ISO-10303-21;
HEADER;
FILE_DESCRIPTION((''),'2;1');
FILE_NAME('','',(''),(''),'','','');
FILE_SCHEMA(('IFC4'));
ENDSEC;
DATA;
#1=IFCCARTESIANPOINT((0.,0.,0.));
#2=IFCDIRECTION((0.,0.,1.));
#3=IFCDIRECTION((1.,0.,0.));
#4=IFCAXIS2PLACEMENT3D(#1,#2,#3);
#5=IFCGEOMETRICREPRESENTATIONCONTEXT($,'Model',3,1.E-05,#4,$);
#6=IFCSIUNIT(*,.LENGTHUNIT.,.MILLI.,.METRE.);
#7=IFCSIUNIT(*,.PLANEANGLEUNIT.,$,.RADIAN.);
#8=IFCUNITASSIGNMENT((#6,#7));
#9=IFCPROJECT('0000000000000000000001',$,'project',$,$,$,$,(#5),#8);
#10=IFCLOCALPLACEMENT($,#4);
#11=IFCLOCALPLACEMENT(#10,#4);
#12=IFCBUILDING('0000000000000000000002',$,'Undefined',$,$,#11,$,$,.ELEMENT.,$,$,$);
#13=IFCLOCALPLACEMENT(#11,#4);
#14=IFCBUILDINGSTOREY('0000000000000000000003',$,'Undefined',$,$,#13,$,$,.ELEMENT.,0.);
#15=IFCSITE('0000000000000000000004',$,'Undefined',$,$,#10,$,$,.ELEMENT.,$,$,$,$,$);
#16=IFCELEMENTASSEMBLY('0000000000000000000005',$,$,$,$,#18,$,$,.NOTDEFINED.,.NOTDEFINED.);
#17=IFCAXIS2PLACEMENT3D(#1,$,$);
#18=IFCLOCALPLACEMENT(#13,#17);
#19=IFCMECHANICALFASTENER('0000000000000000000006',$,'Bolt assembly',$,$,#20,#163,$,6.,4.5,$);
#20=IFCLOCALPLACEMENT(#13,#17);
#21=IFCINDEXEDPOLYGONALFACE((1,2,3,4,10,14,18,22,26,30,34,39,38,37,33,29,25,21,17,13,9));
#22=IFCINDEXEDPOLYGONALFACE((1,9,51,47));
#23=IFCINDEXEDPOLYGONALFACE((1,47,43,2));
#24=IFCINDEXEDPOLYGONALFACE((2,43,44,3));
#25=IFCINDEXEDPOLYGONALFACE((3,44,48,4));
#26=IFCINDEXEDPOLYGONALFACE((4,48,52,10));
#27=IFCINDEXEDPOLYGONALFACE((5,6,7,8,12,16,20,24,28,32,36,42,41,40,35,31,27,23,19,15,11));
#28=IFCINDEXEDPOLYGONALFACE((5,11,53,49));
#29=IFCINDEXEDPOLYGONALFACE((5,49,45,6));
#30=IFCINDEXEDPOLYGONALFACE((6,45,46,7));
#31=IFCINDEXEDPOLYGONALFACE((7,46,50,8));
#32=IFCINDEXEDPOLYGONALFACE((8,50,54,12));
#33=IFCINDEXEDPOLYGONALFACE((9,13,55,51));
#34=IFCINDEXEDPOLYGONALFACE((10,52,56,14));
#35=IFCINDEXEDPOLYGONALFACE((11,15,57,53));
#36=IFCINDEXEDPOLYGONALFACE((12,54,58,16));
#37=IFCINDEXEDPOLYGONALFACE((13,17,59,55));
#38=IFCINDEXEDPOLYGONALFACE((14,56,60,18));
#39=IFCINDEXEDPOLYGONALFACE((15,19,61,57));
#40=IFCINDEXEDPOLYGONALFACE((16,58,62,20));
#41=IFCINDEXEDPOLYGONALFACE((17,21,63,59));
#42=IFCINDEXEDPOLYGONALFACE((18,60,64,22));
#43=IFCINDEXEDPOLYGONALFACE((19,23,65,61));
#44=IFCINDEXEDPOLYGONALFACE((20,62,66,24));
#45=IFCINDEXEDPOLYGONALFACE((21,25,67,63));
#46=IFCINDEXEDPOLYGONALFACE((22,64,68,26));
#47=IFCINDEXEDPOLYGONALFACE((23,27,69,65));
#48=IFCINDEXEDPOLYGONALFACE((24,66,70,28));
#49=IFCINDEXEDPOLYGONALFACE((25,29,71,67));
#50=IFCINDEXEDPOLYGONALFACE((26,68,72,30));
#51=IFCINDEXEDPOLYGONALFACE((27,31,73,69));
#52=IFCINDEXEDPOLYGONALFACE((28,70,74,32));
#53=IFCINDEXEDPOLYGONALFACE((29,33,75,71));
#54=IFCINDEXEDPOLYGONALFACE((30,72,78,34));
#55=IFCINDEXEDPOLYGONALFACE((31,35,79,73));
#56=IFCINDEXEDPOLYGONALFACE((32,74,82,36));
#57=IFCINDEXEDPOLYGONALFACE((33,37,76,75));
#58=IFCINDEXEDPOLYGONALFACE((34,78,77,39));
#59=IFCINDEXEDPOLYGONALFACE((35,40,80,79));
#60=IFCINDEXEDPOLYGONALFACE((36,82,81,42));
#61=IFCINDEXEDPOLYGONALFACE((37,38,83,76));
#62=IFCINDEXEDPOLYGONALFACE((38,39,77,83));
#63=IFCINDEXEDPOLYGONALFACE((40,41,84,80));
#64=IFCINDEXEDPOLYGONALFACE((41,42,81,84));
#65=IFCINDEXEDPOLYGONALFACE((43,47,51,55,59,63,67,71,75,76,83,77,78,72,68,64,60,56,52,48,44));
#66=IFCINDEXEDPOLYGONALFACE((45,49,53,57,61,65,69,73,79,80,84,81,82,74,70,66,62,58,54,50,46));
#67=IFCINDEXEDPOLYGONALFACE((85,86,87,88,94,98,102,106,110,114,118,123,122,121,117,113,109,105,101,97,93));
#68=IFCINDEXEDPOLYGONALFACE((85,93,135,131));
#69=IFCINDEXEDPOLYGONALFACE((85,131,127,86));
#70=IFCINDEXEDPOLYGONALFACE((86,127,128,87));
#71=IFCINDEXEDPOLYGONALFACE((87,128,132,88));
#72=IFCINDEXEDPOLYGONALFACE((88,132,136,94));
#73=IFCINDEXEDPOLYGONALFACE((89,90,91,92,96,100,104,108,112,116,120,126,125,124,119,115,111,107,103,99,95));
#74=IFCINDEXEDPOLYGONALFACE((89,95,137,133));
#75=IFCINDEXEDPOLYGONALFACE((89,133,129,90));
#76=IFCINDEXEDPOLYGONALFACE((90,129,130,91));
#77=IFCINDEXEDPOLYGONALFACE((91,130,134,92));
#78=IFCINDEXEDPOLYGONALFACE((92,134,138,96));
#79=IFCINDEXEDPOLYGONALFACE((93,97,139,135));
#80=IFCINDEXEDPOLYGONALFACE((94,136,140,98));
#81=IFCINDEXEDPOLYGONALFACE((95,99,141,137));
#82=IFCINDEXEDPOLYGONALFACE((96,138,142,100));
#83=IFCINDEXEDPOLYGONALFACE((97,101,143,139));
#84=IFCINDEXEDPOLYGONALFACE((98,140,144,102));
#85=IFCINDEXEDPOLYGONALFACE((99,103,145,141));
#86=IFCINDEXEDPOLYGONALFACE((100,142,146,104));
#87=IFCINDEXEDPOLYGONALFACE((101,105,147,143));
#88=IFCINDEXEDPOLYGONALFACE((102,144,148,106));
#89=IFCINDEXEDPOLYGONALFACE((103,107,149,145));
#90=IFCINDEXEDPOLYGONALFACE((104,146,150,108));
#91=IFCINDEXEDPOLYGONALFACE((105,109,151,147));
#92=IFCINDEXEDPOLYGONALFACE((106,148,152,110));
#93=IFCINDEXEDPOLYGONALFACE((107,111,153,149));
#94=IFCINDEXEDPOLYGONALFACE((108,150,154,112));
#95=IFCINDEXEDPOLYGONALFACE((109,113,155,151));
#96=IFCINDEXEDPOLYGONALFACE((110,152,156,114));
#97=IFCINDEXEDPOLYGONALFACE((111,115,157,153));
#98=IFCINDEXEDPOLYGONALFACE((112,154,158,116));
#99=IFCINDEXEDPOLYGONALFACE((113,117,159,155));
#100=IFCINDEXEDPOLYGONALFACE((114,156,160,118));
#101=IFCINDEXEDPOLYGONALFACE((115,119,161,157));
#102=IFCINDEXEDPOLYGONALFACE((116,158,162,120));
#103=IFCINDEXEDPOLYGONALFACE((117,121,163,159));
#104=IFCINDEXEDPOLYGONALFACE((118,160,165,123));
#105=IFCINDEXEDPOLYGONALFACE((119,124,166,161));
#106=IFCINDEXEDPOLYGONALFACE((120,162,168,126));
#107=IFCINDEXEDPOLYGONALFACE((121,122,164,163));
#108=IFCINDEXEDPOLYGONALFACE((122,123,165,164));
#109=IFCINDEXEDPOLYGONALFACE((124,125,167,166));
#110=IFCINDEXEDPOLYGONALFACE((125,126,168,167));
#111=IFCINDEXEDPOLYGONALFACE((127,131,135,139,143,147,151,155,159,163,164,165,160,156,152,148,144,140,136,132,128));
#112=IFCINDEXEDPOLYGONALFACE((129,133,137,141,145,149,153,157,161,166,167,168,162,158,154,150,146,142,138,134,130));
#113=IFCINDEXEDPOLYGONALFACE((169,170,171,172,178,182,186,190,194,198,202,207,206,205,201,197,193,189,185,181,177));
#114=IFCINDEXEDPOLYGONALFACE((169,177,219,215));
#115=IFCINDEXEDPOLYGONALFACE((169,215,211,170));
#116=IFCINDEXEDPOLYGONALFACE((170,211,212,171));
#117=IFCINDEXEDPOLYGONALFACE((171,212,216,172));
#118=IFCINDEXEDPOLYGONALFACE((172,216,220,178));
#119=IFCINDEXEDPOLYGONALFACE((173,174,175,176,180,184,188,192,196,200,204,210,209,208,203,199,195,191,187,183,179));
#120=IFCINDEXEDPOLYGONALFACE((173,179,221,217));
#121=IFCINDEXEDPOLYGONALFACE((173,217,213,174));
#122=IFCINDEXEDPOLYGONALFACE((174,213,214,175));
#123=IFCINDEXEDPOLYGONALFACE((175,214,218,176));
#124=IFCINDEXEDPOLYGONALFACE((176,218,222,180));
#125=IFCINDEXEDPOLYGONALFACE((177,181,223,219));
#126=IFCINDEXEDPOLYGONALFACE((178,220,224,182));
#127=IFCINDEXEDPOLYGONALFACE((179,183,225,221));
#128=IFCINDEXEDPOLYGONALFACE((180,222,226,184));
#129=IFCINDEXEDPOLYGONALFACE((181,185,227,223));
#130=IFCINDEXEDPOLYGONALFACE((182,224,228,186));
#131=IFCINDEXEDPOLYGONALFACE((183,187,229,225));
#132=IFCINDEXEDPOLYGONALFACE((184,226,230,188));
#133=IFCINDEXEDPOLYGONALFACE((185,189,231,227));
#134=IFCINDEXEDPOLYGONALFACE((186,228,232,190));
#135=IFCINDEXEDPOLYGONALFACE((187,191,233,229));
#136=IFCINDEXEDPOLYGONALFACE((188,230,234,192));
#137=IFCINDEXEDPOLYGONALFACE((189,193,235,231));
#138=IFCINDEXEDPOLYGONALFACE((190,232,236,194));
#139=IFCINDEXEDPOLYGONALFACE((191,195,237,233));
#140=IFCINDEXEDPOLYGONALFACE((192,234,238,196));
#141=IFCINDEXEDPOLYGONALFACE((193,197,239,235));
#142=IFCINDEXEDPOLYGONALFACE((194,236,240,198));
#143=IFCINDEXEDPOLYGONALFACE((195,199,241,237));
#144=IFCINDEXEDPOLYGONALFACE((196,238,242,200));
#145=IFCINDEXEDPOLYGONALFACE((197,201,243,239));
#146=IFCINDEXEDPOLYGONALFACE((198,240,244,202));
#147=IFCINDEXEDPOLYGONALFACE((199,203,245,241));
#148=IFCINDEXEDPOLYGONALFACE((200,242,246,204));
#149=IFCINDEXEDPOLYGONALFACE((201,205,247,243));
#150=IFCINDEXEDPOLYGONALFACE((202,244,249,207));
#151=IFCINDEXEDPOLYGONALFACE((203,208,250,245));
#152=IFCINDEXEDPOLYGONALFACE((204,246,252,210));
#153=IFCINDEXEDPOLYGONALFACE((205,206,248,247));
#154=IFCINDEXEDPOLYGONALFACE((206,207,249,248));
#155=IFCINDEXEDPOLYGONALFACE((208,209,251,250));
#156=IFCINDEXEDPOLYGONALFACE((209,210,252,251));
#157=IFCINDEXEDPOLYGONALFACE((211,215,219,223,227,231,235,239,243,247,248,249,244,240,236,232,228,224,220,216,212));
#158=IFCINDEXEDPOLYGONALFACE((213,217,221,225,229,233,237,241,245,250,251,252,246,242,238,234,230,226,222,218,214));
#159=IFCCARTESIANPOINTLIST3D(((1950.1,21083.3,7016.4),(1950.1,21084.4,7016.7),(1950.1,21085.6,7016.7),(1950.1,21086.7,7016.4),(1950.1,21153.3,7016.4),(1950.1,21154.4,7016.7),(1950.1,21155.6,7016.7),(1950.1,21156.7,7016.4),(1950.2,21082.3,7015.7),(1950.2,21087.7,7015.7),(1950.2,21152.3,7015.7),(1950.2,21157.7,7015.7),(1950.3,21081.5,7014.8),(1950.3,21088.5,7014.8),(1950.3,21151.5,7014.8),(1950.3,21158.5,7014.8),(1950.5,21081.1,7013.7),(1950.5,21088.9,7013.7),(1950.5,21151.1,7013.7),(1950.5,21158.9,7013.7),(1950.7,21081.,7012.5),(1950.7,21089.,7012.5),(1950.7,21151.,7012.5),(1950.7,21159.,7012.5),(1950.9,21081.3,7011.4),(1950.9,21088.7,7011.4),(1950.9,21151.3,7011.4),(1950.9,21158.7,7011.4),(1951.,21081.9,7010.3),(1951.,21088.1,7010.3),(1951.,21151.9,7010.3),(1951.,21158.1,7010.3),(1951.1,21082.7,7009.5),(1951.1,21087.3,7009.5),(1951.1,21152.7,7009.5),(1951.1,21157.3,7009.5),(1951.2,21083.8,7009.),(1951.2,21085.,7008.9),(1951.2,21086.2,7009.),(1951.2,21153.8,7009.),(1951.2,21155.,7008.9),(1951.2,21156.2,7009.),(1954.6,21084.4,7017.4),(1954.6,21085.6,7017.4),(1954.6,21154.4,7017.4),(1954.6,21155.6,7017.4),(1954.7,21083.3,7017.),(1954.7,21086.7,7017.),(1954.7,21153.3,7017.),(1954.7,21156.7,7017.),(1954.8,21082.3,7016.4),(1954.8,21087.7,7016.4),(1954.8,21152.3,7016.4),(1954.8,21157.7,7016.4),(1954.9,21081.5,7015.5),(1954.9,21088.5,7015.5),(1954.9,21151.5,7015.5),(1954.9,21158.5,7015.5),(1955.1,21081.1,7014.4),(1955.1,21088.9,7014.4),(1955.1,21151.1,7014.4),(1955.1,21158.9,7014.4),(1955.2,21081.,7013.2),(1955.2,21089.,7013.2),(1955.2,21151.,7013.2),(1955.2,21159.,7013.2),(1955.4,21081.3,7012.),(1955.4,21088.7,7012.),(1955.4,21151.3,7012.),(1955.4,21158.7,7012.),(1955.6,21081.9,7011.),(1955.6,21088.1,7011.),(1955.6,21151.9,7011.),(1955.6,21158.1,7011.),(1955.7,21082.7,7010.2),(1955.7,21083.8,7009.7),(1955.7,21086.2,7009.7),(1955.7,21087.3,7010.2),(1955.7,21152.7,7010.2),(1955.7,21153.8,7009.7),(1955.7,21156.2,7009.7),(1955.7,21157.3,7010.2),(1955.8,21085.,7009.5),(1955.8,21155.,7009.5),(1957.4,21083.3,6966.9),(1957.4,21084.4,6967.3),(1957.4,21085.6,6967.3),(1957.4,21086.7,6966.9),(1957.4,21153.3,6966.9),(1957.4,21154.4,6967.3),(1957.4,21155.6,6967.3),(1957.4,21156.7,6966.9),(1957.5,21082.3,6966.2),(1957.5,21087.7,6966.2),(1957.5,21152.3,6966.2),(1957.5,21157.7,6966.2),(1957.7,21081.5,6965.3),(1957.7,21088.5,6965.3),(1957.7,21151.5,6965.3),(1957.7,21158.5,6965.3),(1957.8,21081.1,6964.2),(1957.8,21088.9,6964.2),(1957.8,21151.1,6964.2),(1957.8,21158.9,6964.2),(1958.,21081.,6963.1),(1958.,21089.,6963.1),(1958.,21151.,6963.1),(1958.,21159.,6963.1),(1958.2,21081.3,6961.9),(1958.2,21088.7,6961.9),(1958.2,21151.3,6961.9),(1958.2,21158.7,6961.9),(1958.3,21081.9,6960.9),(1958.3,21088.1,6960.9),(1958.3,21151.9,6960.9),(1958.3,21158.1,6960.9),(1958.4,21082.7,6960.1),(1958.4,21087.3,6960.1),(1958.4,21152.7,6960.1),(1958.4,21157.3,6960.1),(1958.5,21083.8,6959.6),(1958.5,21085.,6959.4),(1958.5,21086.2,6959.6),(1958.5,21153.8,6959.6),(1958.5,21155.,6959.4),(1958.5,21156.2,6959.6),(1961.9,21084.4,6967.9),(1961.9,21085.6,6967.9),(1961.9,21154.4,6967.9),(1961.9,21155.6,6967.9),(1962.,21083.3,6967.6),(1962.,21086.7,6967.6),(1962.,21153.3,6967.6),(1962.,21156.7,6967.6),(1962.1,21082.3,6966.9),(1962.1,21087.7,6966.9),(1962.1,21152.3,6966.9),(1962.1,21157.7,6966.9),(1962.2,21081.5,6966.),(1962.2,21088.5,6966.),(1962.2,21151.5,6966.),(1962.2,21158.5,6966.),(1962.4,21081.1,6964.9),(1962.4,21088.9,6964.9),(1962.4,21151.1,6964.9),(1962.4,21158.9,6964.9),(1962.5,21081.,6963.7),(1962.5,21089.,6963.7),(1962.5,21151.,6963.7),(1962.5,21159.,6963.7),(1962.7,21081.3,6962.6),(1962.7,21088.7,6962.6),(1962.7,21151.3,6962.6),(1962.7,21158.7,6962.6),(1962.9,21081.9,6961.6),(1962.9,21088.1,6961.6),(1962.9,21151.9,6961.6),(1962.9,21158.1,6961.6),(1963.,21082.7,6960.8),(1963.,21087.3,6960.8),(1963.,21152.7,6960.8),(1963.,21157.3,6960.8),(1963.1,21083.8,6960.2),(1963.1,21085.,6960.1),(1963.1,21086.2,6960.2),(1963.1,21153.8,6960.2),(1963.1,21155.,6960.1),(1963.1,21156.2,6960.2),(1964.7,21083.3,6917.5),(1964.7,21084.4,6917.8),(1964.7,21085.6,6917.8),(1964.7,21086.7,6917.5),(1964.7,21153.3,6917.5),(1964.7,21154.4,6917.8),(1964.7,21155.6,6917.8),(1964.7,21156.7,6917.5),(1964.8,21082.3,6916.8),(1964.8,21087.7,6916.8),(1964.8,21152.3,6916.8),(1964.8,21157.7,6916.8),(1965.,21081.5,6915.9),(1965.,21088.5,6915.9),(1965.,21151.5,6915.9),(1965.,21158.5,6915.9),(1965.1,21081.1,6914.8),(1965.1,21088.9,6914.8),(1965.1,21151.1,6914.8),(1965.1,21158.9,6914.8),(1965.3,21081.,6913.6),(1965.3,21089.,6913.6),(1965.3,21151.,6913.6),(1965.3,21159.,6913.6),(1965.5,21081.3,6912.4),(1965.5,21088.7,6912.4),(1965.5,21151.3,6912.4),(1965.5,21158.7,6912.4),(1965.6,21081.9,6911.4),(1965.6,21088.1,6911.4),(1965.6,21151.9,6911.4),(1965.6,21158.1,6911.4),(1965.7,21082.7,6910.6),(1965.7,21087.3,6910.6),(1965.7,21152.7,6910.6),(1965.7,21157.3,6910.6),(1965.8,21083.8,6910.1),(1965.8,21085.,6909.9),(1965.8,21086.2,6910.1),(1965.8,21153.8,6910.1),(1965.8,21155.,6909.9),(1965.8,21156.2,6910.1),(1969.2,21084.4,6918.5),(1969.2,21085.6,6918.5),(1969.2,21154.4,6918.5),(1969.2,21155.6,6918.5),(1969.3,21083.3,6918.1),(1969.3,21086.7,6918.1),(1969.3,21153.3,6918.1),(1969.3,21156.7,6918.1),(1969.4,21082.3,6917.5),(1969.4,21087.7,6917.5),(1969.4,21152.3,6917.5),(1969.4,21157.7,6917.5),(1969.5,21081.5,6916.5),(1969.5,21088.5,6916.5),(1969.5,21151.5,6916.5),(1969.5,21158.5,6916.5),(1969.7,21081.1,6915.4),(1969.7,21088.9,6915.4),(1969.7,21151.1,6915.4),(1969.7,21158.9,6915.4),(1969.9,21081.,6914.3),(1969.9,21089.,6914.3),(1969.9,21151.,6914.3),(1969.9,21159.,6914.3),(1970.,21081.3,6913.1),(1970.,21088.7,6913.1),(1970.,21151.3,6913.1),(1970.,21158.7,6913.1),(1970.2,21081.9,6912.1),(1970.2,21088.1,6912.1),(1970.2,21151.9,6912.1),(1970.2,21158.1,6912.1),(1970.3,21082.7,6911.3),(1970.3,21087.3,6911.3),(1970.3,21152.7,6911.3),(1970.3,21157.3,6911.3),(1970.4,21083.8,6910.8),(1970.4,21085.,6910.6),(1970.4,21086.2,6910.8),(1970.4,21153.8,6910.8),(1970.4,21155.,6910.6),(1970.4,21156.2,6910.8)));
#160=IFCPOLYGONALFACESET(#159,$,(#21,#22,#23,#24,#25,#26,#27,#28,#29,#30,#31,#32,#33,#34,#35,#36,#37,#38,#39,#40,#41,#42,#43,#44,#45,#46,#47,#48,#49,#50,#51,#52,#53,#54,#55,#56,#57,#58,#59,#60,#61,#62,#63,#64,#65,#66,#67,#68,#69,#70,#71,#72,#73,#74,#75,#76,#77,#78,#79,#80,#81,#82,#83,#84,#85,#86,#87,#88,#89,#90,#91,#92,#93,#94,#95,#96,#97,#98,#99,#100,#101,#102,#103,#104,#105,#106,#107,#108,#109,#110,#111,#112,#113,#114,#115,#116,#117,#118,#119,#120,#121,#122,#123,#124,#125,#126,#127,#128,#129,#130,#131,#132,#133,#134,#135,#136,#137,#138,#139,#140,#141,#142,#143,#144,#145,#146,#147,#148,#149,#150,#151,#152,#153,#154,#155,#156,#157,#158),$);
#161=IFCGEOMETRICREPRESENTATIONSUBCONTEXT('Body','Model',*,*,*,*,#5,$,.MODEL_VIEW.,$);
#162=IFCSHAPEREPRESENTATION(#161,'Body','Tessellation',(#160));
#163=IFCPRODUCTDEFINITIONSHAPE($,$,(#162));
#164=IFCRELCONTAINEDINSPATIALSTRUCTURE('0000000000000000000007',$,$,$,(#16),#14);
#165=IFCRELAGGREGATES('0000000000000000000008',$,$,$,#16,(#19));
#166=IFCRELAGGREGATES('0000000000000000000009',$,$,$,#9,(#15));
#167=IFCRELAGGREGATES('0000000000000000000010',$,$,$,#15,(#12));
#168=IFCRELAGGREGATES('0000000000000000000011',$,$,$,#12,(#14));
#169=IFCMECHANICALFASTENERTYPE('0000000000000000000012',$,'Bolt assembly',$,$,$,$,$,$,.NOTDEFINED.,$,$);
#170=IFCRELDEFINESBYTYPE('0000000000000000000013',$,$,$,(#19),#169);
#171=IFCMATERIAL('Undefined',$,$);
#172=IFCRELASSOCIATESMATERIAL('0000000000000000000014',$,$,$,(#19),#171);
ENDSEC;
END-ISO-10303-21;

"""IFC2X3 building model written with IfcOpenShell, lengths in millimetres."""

from ifc_helpers import new_model, si_unit, frame, origin_with_axes, origin_2d_with_axis, place, context, subcontext, project, spatial, circle, extrude, source, transform, mapped, material, type_object, element, aggregate, save


model = new_model("IFC2X3")

# Units and contexts
model_context = context("Model", 3, precision=1e-05, world=origin_with_axes())
body_context = subcontext(model_context, "Body", "Model", "MODEL_VIEW")
ifc_project = project(units=[si_unit("LENGTHUNIT", "METRE", prefix="MILLI"), si_unit("PLANEANGLEUNIT", "RADIAN")], contexts=[model_context])

# Site, building, storey
site_placement = place(None, origin_with_axes())
site = spatial("IfcSite", under=ifc_project, at=site_placement, Name="Undefined", CompositionType="ELEMENT")
building_placement = place(site_placement, origin_with_axes())
building = spatial("IfcBuilding", under=site, at=building_placement, Name="Undefined", CompositionType="ELEMENT")
storey_placement = place(building_placement, origin_with_axes())
storey = spatial("IfcBuildingStorey", under=building, at=storey_placement, Name="Undefined", CompositionType="ELEMENT", Elevation=0.0)

# Element assembly
assembly_1_placement = place(storey_placement, origin_with_axes())
assembly_1 = element("IfcElementAssembly", 1, at=assembly_1_placement, inside=storey, AssemblyPlace="NOTDEFINED", PredefinedType="NOTDEFINED")

# Mechanical fastener
ifc_material_1 = material(Name="Undefined")
mechanical_fastener_type = type_object("IfcMechanicalFastenerType", Name="Bolt assembly")
shared_shape_1 = source(origin_with_axes(), body_context, "Body", "SweptSolid", [
    extrude(circle(Radius=4.0, at=origin_2d_with_axis()), frame((0.0, 0.0, 0.0), z_axis=(0.0, 1.0, 0.0), x_axis=(1.0, 0.0, 0.0)), (0.0, 0.0, 1.0), 4.6),
])
mechanical_fastener_1_placement = place(assembly_1_placement, frame((1950.6, 21120.0, 7012.8), z_axis=(0.0, -1.0, 0.0), x_axis=(0.146203, 0.0, -0.989255)))
mechanical_fastener_1 = element("IfcMechanicalFastener", 2, at=mechanical_fastener_1_placement, type_object=mechanical_fastener_type, material=ifc_material_1, Name="Bolt assembly", NominalDiameter=6.0, NominalLength=4.5, context=body_context, shape_type="MappedRepresentation", body=[
    mapped(shared_shape_1, transform((0.0, 0.0, -35.0))),
    mapped(shared_shape_1, transform((50.0, 0.0, -35.0))),
    mapped(shared_shape_1, transform((100.0, 0.0, -35.0))),
    mapped(shared_shape_1, transform((0.0, 0.0, 35.0))),
    mapped(shared_shape_1, transform((50.0, 0.0, 35.0))),
    mapped(shared_shape_1, transform((100.0, 0.0, 35.0))),
])

aggregate(assembly_1, [mechanical_fastener_1])

save(model, "model.ifc")
